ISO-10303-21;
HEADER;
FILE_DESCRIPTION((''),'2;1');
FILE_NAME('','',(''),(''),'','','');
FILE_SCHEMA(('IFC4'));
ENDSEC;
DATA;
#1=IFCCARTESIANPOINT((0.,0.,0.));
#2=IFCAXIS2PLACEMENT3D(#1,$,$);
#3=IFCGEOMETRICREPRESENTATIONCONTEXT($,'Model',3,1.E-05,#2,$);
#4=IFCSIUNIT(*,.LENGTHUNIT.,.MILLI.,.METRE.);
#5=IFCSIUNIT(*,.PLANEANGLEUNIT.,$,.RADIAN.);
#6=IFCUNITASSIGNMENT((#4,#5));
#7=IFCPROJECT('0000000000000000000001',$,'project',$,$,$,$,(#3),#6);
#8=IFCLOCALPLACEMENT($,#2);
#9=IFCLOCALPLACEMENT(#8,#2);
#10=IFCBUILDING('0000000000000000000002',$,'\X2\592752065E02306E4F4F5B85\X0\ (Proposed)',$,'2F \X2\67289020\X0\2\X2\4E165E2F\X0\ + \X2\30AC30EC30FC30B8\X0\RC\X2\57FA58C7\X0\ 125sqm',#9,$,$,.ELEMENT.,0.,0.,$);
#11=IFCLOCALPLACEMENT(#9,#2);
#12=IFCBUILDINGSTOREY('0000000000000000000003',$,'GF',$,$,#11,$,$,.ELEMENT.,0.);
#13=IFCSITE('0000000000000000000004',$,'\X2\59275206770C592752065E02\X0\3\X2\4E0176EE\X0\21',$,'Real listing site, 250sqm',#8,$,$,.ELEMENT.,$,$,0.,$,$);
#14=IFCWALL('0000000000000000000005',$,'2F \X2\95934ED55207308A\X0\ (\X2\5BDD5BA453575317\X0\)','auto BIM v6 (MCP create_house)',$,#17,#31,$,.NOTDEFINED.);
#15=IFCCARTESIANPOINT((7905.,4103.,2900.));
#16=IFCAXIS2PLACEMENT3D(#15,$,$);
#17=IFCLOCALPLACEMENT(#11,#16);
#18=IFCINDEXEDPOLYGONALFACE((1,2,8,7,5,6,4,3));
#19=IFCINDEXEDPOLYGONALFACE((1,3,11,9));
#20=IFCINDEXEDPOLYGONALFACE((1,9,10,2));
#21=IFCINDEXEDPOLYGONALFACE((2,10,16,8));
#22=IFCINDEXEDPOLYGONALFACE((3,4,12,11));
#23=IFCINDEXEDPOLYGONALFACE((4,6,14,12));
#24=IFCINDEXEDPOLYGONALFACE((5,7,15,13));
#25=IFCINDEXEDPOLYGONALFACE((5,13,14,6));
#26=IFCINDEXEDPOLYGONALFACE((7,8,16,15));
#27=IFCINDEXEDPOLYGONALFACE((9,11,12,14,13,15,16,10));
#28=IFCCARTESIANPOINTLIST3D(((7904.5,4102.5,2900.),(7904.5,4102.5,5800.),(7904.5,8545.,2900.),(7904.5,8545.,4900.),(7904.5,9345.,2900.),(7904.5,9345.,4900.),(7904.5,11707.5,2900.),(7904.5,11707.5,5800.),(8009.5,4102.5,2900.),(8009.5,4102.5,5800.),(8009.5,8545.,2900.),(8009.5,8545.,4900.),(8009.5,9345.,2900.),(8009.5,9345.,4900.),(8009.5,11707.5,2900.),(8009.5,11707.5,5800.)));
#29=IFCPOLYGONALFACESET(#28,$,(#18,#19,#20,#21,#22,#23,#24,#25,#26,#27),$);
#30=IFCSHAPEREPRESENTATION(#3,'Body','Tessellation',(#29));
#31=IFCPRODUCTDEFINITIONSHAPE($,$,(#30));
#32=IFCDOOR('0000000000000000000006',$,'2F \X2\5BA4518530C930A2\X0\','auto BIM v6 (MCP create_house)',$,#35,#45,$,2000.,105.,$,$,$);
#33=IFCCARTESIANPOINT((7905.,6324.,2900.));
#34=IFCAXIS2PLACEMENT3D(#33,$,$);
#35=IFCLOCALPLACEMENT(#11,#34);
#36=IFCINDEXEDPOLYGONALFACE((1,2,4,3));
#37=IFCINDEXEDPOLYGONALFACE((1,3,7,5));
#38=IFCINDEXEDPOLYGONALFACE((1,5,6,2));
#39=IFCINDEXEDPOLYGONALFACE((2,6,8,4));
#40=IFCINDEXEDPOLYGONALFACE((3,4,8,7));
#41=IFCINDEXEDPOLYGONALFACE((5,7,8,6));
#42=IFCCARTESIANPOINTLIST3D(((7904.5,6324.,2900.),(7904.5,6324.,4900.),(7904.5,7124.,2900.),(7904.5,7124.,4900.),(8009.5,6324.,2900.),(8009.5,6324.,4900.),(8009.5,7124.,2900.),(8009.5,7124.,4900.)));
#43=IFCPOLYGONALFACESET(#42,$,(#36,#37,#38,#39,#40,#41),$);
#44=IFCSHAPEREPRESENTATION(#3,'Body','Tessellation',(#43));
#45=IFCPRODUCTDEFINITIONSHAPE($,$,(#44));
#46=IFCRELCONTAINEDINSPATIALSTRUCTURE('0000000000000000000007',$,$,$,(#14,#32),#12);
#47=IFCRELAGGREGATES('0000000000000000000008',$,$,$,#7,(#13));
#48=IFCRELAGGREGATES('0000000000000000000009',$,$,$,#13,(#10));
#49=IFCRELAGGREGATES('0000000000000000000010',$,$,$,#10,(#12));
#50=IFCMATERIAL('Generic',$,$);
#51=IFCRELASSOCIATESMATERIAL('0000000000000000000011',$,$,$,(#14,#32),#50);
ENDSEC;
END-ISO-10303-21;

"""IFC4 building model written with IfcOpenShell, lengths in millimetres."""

from ifc_helpers import new_model, si_unit, frame, frame_2d, origin, place, context, project, spatial, rectangle, extrude, material, element, fill, save


model = new_model("IFC4")

# Units and contexts
model_context = context("Model", 3, precision=1e-05, world=origin())
ifc_project = project(units=[si_unit("LENGTHUNIT", "METRE", prefix="MILLI"), si_unit("PLANEANGLEUNIT", "RADIAN")], contexts=[model_context])

# Site, building, storey
site_placement = place(None, origin())
site = spatial("IfcSite", under=ifc_project, at=site_placement, Name="大分県大分市3丁目21", ObjectType="Real listing site, 250sqm", CompositionType="ELEMENT", RefElevation=0.0)
building_placement = place(site_placement, origin())
building = spatial("IfcBuilding", under=site, at=building_placement, Name="大分市の住宅 (Proposed)", ObjectType="2F 木造2世帯 + ガレージRC基壇 125sqm", CompositionType="ELEMENT", ElevationOfRefHeight=0.0, ElevationOfTerrain=0.0)
storey_placement = place(building_placement, origin())
storey = spatial("IfcBuildingStorey", under=building, at=storey_placement, Name="GF", CompositionType="ELEMENT", Elevation=0.0)

# Shared definitions
ifc_material = material(Name="Generic")

# Wall, opening, door
wall_1_placement = place(storey_placement, frame((7905.0, 4103.0, 2900.0)))
wall_1 = element("IfcWall", 1, at=wall_1_placement, inside=storey, material=ifc_material, Name="2F 間仕切り (寝室南北)", Description="auto BIM v6 (MCP create_house)", PredefinedType="NOTDEFINED", context=model_context, shape_type="SweptSolid", body=[
    extrude(rectangle(XDim=105.0, YDim=7605.0, at=frame_2d((52.0, 3802.0))), frame((7905.0, 4103.0, 2900.0)), (0.0, 0.0, 1.0), 2900.0),
])
opening_1_placement = place(storey_placement, frame((7905.0, 6324.0, 2900.0)))
opening_1 = element("IfcOpeningElement", 2, at=opening_1_placement, cuts=wall_1, PredefinedType="NOTDEFINED", context=model_context, shape_type="SweptSolid", body=[
    extrude(rectangle(XDim=105.0, YDim=800.0, at=frame_2d((52.0, 400.0))), frame((7905.0, 6324.0, 2900.0)), (0.0, 0.0, 1.0), 2000.0),
])
door_placement = place(storey_placement, frame((7905.0, 6324.0, 2900.0)))
door = element("IfcDoor", 3, at=door_placement, inside=storey, material=ifc_material, Name="2F 室内ドア", Description="auto BIM v6 (MCP create_house)", OverallHeight=2000.0, OverallWidth=105.0, context=model_context, shape_type="SweptSolid", body=[
    extrude(rectangle(XDim=105.0, YDim=800.0, at=frame_2d((52.0, 400.0))), frame((7905.0, 6324.0, 2900.0)), (0.0, 0.0, 1.0), 2000.0),
])
fill(opening_1, door)

save(model, "model.ifc")
